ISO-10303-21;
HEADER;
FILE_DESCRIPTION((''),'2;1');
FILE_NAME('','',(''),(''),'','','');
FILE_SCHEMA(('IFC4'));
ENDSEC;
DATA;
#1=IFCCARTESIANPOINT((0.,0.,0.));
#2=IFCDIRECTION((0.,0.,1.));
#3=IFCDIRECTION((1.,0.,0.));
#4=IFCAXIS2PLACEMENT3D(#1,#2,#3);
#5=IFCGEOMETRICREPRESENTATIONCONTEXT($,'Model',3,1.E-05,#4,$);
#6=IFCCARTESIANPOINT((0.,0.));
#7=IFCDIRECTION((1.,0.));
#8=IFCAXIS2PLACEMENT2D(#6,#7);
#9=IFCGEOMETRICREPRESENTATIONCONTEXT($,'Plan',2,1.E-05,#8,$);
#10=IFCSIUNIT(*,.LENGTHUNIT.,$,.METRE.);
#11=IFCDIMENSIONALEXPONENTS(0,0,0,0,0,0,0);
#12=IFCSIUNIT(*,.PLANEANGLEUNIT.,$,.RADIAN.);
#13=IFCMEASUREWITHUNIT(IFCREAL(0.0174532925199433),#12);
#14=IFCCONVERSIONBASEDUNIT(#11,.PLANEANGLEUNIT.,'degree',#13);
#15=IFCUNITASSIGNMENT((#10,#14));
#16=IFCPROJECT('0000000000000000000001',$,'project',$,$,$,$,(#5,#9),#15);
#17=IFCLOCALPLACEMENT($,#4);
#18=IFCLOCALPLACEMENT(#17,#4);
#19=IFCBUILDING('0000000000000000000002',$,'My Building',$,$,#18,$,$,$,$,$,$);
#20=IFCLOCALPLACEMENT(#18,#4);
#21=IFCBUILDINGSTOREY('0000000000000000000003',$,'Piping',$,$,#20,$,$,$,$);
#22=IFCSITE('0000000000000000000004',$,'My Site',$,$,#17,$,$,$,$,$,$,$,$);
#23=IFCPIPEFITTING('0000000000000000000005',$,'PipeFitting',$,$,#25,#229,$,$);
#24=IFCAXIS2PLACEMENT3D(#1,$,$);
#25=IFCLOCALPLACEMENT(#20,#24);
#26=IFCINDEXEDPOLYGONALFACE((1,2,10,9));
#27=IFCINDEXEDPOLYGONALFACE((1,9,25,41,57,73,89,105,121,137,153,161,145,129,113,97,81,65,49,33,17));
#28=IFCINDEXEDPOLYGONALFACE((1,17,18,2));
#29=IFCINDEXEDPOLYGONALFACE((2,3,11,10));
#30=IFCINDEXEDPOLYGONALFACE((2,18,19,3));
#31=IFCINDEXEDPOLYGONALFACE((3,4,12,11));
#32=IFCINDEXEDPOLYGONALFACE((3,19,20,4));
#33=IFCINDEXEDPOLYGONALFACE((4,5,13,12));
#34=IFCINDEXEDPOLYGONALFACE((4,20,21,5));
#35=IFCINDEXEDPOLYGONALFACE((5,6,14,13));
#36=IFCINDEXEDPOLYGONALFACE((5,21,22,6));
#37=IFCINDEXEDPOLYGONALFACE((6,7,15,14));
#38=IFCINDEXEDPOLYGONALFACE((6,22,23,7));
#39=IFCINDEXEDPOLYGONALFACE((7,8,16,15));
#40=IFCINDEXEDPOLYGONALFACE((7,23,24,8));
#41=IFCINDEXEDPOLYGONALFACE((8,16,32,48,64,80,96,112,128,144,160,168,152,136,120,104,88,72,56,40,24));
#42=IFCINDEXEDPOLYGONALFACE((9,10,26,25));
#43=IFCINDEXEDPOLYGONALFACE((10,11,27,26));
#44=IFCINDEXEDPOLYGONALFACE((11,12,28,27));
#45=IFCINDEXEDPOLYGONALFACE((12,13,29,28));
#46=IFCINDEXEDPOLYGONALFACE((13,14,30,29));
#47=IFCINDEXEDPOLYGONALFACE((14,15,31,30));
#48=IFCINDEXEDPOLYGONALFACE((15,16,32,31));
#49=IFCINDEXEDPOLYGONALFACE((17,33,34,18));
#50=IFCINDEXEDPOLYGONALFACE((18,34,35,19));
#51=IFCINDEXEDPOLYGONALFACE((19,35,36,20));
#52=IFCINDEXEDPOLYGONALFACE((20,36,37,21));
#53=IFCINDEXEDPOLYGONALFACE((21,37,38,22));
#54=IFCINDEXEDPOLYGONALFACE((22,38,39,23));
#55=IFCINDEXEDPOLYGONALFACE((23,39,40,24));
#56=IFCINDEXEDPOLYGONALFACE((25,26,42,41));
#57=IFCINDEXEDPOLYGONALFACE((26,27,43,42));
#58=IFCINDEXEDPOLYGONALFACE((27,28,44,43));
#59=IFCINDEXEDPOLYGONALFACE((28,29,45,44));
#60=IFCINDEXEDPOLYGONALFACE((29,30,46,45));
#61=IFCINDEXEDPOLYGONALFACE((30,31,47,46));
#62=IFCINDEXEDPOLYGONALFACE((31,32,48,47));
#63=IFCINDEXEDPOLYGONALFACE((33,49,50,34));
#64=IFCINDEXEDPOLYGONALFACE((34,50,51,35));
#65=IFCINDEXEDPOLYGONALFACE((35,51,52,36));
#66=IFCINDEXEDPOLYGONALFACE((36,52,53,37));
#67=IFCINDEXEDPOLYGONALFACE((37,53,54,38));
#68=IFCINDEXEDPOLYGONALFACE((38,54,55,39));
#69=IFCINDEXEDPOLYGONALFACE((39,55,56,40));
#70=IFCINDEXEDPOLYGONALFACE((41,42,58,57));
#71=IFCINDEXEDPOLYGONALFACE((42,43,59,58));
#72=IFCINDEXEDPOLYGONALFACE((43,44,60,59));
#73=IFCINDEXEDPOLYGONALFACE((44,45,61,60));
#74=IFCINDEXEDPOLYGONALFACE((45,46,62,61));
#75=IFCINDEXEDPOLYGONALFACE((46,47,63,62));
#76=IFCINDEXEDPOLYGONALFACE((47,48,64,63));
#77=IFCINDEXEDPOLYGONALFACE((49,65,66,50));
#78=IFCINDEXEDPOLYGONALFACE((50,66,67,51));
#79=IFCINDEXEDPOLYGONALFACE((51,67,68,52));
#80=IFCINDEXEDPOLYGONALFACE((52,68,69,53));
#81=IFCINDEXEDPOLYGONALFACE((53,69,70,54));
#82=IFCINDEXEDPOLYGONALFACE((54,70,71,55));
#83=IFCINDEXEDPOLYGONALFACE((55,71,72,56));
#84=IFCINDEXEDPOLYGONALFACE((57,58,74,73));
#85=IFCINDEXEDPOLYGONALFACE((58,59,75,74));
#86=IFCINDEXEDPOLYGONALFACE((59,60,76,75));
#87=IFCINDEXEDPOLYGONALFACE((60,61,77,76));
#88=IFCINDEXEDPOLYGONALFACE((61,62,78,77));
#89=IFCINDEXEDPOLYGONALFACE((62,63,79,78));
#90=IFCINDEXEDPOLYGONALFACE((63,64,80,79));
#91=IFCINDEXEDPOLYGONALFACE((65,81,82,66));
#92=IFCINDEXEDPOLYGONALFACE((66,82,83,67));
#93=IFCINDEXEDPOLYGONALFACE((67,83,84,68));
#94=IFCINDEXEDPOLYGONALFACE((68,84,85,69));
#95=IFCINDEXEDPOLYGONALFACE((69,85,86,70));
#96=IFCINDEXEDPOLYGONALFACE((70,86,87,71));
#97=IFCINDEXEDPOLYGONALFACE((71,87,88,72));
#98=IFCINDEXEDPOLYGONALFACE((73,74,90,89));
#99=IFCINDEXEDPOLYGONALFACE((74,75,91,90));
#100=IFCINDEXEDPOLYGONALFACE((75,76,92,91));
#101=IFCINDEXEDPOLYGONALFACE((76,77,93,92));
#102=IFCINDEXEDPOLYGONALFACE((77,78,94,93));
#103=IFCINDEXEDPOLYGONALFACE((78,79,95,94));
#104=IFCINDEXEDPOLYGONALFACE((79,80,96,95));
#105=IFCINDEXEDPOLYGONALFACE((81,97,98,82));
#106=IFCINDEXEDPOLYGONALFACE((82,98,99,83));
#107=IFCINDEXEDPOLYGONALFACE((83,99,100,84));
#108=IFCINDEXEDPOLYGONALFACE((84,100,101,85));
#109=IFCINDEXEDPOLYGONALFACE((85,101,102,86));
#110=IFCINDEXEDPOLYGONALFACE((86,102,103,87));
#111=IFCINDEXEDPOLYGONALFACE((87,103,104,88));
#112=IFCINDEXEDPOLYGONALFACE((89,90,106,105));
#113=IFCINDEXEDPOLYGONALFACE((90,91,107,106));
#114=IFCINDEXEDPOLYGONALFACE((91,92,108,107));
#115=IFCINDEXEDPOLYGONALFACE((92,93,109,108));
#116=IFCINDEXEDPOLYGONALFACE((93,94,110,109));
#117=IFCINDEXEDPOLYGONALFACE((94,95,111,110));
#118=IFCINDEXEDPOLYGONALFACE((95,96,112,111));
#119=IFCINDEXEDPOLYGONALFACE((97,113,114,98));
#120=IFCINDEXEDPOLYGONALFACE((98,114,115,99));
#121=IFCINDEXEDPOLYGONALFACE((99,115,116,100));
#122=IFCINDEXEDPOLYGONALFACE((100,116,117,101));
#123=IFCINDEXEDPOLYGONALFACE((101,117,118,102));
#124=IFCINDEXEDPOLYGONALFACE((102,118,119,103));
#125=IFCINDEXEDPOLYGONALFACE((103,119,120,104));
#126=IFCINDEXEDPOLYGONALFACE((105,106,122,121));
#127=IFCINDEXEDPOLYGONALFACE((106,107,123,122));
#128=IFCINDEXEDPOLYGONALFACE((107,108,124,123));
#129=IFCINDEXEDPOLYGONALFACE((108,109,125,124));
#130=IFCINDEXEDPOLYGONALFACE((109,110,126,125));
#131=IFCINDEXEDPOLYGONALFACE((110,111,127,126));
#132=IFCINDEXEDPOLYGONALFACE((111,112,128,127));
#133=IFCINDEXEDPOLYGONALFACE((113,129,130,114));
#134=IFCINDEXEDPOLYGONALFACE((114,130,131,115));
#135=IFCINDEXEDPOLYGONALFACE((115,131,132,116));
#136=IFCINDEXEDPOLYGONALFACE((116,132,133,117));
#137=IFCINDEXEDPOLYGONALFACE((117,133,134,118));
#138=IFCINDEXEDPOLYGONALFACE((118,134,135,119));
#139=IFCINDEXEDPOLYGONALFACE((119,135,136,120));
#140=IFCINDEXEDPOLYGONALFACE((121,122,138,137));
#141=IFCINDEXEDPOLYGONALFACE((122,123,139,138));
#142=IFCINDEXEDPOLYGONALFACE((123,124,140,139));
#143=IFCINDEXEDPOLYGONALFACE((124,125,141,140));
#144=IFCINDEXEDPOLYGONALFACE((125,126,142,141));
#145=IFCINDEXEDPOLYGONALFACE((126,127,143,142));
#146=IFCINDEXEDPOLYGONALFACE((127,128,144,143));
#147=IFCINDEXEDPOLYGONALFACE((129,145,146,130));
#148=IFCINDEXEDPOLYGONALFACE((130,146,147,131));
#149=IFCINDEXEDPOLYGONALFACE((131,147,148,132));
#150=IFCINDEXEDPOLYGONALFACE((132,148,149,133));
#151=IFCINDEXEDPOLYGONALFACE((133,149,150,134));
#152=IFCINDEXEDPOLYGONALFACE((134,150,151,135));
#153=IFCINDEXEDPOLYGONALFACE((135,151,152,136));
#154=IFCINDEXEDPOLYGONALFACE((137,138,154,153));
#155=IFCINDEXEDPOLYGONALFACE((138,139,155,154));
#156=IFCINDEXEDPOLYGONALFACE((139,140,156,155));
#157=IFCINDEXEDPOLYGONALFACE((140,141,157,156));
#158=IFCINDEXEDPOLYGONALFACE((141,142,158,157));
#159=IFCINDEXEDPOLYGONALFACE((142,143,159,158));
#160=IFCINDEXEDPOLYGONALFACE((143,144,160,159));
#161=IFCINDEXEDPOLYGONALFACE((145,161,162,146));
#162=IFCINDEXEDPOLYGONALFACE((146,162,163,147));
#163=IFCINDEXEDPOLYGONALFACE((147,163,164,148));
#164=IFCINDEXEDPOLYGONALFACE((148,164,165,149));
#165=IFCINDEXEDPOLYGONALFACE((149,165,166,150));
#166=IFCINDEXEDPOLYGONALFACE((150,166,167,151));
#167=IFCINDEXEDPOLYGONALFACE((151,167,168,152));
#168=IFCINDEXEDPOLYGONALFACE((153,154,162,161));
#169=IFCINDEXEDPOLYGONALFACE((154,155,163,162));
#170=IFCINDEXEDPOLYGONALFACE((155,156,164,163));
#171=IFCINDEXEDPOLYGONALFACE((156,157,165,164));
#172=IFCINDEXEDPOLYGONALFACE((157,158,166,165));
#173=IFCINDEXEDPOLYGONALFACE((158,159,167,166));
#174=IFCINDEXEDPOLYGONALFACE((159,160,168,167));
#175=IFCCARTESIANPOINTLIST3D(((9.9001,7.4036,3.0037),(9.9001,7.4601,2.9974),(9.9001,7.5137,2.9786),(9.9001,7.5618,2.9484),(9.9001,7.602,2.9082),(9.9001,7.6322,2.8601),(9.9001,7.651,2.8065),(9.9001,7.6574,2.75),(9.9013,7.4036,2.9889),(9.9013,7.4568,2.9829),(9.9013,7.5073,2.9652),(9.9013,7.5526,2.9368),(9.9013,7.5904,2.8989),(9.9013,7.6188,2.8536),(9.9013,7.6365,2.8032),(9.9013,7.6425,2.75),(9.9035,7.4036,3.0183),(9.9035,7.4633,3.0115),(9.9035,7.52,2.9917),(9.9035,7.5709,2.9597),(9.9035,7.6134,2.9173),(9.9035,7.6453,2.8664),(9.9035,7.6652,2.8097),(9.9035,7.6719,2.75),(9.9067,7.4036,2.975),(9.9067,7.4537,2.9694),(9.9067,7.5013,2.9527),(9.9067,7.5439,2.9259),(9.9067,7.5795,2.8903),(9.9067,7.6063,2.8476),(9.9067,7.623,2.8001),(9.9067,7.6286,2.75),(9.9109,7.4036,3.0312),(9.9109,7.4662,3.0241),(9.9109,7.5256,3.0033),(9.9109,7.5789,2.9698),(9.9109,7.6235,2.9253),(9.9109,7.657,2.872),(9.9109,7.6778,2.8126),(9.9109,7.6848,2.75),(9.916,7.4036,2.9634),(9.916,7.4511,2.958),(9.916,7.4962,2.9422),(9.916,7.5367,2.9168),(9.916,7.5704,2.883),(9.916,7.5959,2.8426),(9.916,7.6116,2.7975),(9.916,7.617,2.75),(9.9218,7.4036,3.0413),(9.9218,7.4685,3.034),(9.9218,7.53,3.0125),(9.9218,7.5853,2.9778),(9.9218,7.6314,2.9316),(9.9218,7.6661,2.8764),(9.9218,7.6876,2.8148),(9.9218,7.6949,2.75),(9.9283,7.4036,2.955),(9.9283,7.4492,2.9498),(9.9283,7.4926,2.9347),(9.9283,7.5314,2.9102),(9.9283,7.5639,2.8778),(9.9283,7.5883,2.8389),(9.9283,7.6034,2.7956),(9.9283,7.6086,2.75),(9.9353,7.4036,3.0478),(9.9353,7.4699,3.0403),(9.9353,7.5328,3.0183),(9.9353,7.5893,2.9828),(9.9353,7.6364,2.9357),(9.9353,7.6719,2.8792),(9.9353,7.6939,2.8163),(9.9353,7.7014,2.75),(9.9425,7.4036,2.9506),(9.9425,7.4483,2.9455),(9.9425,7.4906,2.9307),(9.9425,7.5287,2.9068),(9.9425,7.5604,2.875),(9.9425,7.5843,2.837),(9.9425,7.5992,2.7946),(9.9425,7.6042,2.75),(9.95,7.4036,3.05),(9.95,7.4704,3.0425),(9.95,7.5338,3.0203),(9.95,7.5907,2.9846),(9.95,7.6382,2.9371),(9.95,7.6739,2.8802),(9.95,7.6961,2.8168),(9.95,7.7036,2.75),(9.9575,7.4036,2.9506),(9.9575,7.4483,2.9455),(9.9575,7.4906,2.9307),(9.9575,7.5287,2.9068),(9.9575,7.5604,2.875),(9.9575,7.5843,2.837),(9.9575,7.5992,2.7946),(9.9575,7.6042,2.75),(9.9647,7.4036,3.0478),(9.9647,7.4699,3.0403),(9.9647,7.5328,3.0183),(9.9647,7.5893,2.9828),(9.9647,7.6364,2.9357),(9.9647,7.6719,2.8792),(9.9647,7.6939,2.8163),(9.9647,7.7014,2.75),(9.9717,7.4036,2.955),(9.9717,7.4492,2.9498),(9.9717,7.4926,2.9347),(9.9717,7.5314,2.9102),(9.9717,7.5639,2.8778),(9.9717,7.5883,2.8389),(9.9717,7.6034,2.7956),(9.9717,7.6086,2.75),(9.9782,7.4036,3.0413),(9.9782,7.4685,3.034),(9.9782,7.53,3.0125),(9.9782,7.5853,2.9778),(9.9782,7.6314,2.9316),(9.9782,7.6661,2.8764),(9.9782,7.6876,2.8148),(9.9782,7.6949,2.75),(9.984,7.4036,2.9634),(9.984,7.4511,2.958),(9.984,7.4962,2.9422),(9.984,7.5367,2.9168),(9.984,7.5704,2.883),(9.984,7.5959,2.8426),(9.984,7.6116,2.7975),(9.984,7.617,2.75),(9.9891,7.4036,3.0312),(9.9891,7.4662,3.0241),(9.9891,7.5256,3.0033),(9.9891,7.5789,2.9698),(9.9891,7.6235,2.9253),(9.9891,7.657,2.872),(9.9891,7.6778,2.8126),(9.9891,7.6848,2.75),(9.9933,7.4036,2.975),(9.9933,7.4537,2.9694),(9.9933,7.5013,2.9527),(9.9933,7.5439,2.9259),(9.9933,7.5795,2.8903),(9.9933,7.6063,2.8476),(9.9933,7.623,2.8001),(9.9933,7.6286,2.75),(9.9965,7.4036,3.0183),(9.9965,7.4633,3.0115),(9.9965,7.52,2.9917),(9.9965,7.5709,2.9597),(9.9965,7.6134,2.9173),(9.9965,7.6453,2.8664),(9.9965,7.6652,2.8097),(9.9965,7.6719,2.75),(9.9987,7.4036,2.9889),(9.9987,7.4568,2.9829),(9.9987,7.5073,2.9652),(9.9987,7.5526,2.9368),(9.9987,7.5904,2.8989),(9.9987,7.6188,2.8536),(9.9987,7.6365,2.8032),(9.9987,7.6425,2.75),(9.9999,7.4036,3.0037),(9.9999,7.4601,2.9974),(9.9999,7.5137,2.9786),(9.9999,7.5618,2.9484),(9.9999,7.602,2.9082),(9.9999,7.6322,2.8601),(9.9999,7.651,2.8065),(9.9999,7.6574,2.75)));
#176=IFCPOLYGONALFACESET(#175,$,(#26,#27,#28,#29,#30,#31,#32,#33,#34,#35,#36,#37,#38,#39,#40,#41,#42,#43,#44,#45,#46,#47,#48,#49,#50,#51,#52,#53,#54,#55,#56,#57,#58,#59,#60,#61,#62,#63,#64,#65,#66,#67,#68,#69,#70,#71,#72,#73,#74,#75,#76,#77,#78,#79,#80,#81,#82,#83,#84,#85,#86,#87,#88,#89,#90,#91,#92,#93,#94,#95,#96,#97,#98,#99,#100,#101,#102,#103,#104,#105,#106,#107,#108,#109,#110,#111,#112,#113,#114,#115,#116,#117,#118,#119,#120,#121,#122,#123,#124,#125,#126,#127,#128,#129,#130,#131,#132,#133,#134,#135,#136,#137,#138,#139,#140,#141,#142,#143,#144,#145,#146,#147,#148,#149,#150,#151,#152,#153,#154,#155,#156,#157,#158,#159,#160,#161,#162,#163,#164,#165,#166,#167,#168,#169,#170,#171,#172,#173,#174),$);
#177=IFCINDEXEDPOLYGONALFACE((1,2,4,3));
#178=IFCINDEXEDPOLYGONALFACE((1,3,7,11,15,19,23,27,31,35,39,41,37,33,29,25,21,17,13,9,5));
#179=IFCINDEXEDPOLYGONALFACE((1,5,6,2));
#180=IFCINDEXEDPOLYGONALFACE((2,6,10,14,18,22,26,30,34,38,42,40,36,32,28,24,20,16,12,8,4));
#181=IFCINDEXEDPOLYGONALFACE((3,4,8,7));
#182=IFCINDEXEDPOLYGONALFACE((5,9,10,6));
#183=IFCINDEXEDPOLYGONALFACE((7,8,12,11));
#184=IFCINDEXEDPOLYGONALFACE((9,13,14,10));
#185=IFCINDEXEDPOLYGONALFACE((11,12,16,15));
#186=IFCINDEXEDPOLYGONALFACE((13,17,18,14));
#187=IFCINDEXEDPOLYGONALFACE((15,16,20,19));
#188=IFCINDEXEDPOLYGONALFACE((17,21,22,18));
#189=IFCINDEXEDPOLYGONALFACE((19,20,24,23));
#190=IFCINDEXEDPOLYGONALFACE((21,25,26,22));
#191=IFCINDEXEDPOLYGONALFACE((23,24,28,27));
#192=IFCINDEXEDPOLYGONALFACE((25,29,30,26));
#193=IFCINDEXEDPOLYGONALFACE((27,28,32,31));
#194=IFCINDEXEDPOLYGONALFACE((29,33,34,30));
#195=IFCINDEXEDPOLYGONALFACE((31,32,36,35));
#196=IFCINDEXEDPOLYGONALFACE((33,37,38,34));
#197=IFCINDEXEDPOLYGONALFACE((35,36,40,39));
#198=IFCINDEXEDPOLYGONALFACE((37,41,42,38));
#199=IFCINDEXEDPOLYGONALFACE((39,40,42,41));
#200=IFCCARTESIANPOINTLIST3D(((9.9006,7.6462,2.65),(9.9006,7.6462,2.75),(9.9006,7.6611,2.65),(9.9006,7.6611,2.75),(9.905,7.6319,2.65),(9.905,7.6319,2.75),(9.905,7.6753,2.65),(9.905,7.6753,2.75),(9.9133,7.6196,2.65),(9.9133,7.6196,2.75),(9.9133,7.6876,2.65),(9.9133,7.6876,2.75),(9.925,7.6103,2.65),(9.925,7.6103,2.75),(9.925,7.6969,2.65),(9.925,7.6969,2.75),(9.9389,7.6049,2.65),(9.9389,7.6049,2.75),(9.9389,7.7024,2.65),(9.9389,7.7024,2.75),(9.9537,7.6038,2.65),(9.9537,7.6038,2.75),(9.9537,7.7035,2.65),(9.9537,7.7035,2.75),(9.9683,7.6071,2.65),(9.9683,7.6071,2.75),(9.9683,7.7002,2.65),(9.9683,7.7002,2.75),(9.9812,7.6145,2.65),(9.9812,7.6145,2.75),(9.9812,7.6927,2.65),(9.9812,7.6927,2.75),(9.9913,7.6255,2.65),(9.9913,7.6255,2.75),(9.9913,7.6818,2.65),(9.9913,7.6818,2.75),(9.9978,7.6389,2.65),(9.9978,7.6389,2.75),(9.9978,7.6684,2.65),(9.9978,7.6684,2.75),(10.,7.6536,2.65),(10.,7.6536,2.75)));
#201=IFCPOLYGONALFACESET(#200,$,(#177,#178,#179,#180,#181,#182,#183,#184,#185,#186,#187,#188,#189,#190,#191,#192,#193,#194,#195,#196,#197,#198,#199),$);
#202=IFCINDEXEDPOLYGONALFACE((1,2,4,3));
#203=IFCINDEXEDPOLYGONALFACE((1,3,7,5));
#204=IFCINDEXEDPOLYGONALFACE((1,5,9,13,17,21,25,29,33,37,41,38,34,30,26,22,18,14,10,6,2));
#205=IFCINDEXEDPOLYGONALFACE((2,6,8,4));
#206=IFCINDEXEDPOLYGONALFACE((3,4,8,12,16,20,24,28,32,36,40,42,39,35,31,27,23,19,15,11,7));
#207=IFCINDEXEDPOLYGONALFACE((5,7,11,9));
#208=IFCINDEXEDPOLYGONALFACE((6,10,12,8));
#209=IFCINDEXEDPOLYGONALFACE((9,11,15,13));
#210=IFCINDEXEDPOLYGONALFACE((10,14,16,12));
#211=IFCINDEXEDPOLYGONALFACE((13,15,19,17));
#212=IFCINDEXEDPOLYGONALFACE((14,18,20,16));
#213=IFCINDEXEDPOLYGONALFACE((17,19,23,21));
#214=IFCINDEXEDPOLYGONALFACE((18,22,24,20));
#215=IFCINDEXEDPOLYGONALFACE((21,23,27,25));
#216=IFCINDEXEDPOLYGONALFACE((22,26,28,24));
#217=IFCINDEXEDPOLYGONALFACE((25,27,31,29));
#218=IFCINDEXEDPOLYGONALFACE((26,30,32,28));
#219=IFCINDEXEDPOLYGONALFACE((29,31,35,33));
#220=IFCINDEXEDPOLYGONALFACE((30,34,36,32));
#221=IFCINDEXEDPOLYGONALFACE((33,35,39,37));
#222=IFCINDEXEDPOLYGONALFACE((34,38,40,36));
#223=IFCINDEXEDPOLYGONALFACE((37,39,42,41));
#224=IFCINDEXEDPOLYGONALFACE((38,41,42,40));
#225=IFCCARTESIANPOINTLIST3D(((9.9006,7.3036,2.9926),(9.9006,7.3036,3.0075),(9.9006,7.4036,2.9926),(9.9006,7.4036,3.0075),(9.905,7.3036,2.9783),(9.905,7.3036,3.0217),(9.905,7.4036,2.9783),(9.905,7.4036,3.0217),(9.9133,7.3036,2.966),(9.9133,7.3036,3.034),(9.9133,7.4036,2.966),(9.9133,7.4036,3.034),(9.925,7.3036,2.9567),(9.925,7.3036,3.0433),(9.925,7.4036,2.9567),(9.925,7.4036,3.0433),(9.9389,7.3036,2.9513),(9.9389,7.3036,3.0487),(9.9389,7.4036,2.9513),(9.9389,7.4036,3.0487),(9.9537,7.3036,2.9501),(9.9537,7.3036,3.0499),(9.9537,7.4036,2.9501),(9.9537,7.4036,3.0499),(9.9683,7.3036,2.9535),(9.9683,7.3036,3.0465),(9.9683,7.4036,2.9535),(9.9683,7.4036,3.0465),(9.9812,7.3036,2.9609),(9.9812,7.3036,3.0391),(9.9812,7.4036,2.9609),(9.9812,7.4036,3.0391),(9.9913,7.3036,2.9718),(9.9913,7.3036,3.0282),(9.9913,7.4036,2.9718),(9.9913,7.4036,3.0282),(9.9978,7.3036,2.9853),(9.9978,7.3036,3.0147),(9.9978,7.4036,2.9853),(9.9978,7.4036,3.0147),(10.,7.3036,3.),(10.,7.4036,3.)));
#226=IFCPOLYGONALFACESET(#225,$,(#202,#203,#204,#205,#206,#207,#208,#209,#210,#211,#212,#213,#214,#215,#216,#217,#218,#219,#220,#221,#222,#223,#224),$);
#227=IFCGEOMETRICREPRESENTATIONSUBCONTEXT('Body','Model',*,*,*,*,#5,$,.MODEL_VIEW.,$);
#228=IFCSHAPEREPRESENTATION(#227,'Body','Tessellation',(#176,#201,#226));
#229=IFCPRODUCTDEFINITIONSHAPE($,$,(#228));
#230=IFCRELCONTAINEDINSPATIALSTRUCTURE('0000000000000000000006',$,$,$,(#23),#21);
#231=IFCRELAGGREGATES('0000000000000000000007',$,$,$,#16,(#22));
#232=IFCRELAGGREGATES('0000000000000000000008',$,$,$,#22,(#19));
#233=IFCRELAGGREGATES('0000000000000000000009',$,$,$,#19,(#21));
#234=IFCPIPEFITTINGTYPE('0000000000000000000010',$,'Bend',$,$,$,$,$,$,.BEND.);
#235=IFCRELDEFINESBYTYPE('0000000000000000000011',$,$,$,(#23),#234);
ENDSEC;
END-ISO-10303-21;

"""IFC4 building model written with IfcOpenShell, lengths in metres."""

from ifc_helpers import new_model, entity, si_unit, converted_unit, frame, origin_with_axes, origin_2d_with_axis, place, context, subcontext, project, spatial, circle, extrude, source, transform, mapped, type_object, type_shapes, element, save


model = new_model("IFC4")

# Units and contexts
model_context = context("Model", 3, precision=1e-05, world=origin_with_axes())
plan_context = context("Plan", 2, precision=1e-05, world=origin_2d_with_axis())
body_context = subcontext(model_context, "Body", "Model", "MODEL_VIEW")
ifc_project = project(units=[si_unit("LENGTHUNIT", "METRE"), converted_unit("PLANEANGLEUNIT", "degree", entity("IfcReal", 0.0174532925199433), si_unit("PLANEANGLEUNIT", "RADIAN"), dimensions=[0, 0, 0, 0, 0, 0, 0])], contexts=[model_context, plan_context])

# Site, building, storey
site_placement = place(None, origin_with_axes())
site = spatial("IfcSite", under=ifc_project, at=site_placement, Name="My Site")
building_placement = place(site_placement, origin_with_axes())
building = spatial("IfcBuilding", under=site, at=building_placement, Name="My Building")
storey_placement = place(building_placement, origin_with_axes())
storey = spatial("IfcBuildingStorey", under=building, at=storey_placement, Name="Piping")

# Pipe fitting
pipe_fitting_type = type_object("IfcPipeFittingType", Name="Bend", PredefinedType="BEND")
shared_shape = source(origin_with_axes(), body_context, "Body", "SolidModel", [
    entity("IfcSweptDiskSolid", entity("IfcIndexedPolyCurve", entity("IfcCartesianPointList3D", [[0.0, 0.0, -0.1], [0.0, 0.0732, -0.2768], [0.0, 0.25, -0.35]]), [entity("IfcArcIndex", [1, 2, 3])]), 0.05),
    extrude(circle(Radius=0.05), origin_with_axes(), (0.0, 0.0, -1.0), 0.1),
    extrude(circle(Radius=0.05), frame((0.0, 0.25, -0.35), z_axis=(0.0, 1.0, 0.0), x_axis=(1.0, 0.0, 0.0)), (0.0, 0.0, 1.0), 0.1),
])
type_shapes(pipe_fitting_type, [shared_shape])
for number, where, z_axis, x_axis, name in (
    (1, (9.95, 7.6536, 2.65), (0.0, 0.0, -1.0), (1.0, 0.0, 0.0), "PipeFitting"),
):
    element("IfcPipeFitting", number, at=place(storey_placement, frame(where, z_axis=z_axis, x_axis=x_axis)), inside=storey, type_object=pipe_fitting_type, Name=name, context=body_context, shape_type="MappedRepresentation", body=[
        mapped(shared_shape, transform((0.0, 0.0, 0.0), x_axis=(1.0, 0.0, 0.0), y_axis=(0.0, 1.0, 0.0), z_axis=(0.0, 0.0, 1.0), scale=1.0)),
    ])

save(model, "model.ifc")
